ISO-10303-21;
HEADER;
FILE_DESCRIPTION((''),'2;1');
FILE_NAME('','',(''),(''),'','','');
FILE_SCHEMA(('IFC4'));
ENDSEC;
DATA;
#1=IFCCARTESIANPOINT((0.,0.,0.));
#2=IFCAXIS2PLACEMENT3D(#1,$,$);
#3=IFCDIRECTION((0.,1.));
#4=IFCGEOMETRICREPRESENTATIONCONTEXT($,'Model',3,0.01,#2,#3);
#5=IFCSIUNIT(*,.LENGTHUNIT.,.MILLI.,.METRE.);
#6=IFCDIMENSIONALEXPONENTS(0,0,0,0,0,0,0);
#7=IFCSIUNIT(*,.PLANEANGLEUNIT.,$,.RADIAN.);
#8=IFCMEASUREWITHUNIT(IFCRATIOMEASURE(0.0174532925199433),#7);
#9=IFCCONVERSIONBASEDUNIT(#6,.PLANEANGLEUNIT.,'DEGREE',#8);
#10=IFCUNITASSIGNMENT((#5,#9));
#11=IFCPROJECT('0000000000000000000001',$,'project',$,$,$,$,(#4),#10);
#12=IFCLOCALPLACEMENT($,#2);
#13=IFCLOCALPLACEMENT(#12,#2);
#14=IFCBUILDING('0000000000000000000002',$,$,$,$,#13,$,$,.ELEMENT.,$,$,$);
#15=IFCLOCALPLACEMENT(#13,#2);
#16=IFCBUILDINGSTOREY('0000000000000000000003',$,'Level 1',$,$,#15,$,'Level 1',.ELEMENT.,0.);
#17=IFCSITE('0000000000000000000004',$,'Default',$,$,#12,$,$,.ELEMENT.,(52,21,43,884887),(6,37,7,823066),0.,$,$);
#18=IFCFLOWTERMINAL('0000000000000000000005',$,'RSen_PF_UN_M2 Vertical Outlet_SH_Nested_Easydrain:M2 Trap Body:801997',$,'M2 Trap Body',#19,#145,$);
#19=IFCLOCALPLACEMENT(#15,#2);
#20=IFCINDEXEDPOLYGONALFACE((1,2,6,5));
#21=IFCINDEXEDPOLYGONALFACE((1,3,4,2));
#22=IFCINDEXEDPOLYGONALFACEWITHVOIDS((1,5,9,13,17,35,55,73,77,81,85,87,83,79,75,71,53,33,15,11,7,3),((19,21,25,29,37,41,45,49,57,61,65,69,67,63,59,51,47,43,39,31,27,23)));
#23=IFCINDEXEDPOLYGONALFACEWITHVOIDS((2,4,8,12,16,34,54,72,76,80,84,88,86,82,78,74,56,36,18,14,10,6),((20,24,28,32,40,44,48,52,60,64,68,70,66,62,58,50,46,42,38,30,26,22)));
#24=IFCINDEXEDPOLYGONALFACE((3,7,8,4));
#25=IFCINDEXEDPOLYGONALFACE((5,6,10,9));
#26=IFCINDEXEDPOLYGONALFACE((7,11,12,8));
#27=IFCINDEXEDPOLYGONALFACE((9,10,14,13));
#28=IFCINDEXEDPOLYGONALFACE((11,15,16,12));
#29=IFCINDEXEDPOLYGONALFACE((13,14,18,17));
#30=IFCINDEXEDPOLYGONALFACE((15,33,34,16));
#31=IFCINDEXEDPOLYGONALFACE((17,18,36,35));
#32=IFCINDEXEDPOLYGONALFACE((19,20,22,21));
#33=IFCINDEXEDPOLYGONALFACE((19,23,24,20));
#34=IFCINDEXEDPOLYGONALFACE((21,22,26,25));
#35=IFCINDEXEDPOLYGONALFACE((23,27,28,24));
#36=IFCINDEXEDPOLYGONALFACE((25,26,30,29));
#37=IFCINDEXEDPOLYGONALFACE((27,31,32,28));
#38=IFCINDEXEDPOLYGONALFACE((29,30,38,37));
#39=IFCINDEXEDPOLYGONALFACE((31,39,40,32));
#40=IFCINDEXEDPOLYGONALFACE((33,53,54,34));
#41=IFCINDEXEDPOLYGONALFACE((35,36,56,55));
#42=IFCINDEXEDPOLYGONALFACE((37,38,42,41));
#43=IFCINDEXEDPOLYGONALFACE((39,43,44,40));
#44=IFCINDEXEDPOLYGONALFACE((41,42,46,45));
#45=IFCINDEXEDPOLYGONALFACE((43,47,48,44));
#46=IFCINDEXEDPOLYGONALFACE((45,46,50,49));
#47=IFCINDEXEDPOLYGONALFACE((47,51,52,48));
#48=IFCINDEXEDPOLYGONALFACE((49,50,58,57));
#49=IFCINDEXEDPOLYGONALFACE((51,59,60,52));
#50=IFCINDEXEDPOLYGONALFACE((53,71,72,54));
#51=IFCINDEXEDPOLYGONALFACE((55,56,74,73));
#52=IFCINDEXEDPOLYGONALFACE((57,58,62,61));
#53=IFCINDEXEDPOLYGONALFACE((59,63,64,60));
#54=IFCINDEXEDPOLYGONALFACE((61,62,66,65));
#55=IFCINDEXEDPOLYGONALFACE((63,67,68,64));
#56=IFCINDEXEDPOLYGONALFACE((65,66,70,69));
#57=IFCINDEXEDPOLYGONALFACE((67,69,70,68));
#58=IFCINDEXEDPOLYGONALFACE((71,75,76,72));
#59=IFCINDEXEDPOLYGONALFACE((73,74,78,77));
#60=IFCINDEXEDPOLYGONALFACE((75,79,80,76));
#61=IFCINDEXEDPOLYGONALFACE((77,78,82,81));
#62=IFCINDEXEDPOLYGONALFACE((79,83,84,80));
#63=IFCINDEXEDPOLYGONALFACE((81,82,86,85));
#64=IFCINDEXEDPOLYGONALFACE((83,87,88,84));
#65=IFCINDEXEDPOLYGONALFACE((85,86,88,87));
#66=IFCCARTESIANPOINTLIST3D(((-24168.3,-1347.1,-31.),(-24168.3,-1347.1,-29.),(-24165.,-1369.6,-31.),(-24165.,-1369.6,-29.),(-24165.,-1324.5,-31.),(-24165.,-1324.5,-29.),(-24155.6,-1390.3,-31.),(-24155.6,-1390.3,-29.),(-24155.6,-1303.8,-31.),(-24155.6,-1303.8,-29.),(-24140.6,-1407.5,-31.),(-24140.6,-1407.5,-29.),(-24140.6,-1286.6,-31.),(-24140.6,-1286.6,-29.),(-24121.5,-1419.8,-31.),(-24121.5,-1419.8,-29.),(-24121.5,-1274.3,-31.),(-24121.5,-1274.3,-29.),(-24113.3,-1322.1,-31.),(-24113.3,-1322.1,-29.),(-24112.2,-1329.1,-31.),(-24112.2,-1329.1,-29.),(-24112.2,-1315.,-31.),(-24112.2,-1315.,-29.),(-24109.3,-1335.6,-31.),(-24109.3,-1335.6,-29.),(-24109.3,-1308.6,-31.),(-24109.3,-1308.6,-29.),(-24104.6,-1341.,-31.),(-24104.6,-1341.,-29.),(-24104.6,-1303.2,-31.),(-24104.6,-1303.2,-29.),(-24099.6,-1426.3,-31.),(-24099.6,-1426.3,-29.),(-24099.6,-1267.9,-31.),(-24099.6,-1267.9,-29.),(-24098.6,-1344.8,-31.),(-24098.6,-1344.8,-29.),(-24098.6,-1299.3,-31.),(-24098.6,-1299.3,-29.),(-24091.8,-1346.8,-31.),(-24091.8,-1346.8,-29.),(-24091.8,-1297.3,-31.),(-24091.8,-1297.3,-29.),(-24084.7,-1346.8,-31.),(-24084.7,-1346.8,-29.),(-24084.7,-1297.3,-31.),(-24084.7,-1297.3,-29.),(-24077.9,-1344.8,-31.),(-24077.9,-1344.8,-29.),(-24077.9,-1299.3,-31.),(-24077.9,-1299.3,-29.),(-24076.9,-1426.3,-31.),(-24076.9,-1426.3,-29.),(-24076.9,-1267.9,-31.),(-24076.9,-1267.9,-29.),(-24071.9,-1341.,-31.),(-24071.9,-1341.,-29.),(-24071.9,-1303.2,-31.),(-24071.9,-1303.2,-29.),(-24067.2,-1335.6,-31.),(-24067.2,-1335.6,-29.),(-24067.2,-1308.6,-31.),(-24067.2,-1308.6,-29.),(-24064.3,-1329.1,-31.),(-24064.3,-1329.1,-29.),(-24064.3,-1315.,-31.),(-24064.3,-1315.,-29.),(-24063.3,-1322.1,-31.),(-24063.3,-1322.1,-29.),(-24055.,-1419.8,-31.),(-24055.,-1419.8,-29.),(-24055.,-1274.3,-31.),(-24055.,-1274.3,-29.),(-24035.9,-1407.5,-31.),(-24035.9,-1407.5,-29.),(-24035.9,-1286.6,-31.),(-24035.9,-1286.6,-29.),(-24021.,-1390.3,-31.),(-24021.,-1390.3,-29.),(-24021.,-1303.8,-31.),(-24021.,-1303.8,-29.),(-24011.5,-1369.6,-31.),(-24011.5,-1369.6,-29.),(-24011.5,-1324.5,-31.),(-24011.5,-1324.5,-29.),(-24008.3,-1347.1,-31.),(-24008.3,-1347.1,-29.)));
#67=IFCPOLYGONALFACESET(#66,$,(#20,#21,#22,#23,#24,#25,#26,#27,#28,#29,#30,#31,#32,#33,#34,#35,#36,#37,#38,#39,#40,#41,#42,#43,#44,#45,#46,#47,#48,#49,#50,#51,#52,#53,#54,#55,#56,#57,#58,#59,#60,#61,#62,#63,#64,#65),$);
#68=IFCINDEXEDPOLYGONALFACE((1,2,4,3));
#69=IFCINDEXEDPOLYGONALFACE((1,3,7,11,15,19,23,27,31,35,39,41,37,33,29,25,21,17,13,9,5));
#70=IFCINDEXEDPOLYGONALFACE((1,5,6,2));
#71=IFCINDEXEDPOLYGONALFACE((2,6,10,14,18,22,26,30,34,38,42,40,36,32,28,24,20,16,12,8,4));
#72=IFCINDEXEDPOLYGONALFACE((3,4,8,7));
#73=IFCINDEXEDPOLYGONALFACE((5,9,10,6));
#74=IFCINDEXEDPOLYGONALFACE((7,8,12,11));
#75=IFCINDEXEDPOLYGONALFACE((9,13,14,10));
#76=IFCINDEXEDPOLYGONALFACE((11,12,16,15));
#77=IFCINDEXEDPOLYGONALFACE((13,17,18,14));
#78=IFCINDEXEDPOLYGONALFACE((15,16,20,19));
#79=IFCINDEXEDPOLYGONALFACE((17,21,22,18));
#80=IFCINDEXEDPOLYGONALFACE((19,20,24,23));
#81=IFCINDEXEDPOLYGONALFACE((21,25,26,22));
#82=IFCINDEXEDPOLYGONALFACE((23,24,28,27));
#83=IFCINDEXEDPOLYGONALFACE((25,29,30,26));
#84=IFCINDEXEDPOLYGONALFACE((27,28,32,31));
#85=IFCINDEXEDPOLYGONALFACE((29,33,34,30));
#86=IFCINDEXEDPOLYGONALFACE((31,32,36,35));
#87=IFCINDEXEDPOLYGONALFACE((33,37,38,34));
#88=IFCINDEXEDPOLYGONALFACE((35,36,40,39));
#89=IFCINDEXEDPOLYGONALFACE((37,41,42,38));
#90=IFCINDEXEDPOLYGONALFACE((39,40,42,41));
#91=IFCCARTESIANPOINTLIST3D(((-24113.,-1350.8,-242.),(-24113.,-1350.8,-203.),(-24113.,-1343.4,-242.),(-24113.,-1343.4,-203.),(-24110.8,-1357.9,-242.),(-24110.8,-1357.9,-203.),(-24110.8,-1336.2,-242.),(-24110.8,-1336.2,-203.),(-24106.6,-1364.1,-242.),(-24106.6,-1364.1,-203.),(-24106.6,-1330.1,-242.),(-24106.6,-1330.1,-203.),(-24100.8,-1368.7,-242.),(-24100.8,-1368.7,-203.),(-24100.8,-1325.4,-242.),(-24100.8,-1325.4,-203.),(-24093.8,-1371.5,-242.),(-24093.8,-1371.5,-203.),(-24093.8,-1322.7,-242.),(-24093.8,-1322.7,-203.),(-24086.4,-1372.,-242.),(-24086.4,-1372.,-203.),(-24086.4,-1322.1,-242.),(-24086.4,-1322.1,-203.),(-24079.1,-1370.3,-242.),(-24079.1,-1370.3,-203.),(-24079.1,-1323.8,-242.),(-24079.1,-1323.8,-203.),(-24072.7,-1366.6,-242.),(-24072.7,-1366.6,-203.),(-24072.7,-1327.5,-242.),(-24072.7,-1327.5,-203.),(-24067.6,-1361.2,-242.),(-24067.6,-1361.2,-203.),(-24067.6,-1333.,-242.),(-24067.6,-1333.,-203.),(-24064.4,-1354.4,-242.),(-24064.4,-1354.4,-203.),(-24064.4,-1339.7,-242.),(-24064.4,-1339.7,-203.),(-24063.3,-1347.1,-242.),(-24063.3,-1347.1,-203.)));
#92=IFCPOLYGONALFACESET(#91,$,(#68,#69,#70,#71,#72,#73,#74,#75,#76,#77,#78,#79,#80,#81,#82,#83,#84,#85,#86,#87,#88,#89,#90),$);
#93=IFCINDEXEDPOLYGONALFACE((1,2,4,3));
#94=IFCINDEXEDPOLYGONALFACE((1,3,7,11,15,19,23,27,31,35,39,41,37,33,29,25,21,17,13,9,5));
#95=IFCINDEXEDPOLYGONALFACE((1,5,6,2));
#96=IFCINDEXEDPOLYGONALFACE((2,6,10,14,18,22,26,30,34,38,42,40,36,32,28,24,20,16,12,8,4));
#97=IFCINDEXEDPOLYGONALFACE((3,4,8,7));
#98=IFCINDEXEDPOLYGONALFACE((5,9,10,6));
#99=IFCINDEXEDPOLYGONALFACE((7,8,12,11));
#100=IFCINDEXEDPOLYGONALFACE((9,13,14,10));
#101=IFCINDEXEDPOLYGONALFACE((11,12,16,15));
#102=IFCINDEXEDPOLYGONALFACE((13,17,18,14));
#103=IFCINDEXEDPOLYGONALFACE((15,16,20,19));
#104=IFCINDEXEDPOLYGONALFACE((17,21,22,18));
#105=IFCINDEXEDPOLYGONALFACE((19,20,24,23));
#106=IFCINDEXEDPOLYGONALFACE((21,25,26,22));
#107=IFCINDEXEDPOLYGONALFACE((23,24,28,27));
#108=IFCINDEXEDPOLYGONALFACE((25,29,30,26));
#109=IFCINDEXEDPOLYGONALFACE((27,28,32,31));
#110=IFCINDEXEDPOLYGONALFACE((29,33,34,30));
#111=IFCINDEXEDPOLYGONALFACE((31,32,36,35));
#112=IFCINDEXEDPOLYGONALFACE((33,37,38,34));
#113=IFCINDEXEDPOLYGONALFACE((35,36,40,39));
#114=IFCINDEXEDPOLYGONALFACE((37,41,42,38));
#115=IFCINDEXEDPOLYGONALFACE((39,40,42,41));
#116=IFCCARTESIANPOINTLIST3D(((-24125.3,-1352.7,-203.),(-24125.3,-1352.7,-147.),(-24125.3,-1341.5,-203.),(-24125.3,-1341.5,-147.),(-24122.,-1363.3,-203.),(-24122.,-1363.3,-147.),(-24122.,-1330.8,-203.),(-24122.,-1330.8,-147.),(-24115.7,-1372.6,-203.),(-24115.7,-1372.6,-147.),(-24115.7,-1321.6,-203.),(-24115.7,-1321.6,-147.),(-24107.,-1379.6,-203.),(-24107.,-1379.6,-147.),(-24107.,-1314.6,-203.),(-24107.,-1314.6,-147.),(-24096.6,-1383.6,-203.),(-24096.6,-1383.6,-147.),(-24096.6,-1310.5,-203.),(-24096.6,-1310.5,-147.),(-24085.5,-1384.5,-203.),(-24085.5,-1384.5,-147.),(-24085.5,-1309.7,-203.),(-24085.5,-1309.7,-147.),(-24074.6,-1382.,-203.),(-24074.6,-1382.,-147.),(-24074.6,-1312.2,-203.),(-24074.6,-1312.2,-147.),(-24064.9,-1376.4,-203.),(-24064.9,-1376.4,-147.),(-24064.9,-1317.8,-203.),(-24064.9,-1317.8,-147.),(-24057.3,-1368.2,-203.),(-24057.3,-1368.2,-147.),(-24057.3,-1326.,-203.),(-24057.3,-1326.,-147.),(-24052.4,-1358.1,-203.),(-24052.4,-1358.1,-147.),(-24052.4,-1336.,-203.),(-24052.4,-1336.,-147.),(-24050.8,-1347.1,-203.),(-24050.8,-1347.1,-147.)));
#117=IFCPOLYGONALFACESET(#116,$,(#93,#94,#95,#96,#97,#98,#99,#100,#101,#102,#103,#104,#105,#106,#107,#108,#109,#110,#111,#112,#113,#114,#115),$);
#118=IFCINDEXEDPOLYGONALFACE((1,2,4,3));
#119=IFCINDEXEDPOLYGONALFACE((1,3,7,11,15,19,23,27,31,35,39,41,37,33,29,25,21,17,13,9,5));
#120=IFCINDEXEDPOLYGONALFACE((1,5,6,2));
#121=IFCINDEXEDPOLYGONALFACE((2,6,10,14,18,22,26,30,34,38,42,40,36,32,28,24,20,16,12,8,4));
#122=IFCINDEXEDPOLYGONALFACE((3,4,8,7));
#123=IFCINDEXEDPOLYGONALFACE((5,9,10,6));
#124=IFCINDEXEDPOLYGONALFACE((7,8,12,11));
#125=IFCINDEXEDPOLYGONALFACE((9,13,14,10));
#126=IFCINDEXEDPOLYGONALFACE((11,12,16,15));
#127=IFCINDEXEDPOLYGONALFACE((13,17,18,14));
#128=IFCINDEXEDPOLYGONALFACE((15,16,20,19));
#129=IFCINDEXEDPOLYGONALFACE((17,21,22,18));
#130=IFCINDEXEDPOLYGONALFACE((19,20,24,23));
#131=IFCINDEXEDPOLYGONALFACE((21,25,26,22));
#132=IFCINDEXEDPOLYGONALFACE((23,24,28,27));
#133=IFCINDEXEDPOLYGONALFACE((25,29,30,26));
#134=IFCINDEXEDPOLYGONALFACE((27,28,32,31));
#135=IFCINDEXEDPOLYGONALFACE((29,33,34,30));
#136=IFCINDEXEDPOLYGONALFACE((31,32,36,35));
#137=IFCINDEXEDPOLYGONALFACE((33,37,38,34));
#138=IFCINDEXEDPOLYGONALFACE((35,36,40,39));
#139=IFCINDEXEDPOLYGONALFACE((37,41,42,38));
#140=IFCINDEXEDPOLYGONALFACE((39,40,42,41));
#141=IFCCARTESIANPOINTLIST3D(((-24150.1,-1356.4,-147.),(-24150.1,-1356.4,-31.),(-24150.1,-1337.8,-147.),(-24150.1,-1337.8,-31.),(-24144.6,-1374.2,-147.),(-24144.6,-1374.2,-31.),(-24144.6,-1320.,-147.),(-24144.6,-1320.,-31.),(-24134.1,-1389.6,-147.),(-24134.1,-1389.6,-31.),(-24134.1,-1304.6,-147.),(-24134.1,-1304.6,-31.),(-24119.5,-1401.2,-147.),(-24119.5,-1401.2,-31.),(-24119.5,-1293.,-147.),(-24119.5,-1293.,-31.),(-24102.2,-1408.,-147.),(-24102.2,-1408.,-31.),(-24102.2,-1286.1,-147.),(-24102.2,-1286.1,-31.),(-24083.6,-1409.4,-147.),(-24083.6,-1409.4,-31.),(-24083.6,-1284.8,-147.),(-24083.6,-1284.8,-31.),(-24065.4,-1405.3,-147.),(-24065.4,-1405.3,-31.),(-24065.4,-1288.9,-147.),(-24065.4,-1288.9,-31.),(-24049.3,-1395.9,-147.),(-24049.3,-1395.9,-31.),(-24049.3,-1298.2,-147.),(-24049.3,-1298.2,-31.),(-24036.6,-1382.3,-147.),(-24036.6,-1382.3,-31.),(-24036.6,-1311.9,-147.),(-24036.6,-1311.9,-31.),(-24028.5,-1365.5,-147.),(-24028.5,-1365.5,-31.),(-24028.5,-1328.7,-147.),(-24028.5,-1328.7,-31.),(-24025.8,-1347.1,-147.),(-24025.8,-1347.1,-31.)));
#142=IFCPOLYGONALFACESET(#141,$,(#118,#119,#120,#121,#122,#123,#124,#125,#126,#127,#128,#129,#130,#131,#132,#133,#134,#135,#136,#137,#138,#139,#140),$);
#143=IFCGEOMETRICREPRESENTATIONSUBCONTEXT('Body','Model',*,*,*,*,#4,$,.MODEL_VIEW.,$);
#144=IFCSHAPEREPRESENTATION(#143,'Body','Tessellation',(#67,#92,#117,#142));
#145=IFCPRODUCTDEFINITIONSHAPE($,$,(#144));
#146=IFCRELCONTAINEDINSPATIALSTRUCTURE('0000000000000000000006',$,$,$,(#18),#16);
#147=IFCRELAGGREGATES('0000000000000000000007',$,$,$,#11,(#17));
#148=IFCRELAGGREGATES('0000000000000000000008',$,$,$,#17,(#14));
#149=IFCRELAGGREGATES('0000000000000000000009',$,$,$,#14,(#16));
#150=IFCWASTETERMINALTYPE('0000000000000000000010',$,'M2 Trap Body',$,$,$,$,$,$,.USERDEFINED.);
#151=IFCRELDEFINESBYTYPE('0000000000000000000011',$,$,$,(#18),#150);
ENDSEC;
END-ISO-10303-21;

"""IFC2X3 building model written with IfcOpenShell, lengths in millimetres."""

from ifc_helpers import new_model, entity, si_unit, converted_unit, direction, frame, frame_2d, origin, origin_2d_with_axis, place, context, subcontext, project, spatial, circle_curve, parameter, trimmed, segment, composite_curve, circle, outline, extrude, source, transform, mapped, type_object, type_shapes, element, save


model = new_model("IFC2X3")

# Units and contexts
model_context = context("Model", 3, precision=0.01, world=origin(), true_north=direction((0.0, 1.0)))
body_context = subcontext(model_context, "Body", "Model", "MODEL_VIEW")
ifc_project = project(units=[si_unit("LENGTHUNIT", "METRE", prefix="MILLI"), converted_unit("PLANEANGLEUNIT", "DEGREE", entity("IfcRatioMeasure", 0.0174532925199433), si_unit("PLANEANGLEUNIT", "RADIAN"), dimensions=[0, 0, 0, 0, 0, 0, 0])], contexts=[model_context])

# Site, building, storey
site_placement = place(None, origin())
site = spatial("IfcSite", under=ifc_project, at=site_placement, Name="Default", CompositionType="ELEMENT", RefLatitude=(52, 21, 43, 884887), RefLongitude=(6, 37, 7, 823066), RefElevation=0.0)
building_placement = place(site_placement, origin())
building = spatial("IfcBuilding", under=site, at=building_placement, CompositionType="ELEMENT")
storey_placement = place(building_placement, origin())
storey = spatial("IfcBuildingStorey", under=building, at=storey_placement, Name="Level 1", LongName="Level 1", CompositionType="ELEMENT", Elevation=0.0)

# Flow terminal
waste_terminal_type_1 = type_object("IfcWasteTerminalType", Name="M2 Trap Body", PredefinedType="USERDEFINED")
shared_shape_1 = source(origin(), body_context, "Body", "SweptSolid", [
    extrude(outline(composite_curve([segment(trimmed(circle_curve(origin_2d_with_axis(), 80.0), [parameter(0.0)], [parameter(180.0)], True, "PARAMETER"), True, "CONTINUOUS"), segment(trimmed(circle_curve(origin_2d_with_axis(), 80.0), [parameter(180.0)], [parameter(360.0)], True, "PARAMETER"), True, "CONTINUOUS")], self_intersect=False), holes=[composite_curve([segment(trimmed(circle_curve(frame_2d((0.0, 25.0), x_axis=(1.0, 0.0)), 25.0), [parameter(180.0)], [parameter(360.0)], True, "PARAMETER"), False, "CONTINUOUS"), segment(trimmed(circle_curve(frame_2d((0.0, 25.0), x_axis=(1.0, 0.0)), 25.0), [parameter(0.0)], [parameter(180.0)], True, "PARAMETER"), False, "CONTINUOUS")], self_intersect=False)]), frame((0.0, -25.0, -2.0)), (0.0, 0.0, 1.0), 2.0),
    extrude(circle(Radius=25.0, at=frame_2d((0.0, 0.0), x_axis=(1.0, 0.0))), frame((0.0, -25.0, -213.0)), (0.0, 0.0, 1.0), 39.0),
    extrude(circle(Radius=37.5, at=frame_2d((0.0, 0.0), x_axis=(1.0, 0.0))), frame((0.0, -25.0, -174.0)), (0.0, 0.0, 1.0), 56.0),
    extrude(circle(Radius=62.5, at=frame_2d((0.0, 0.0), x_axis=(1.0, 0.0))), frame((0.0, -25.0, -118.0)), (0.0, 0.0, 1.0), 116.0),
])
type_shapes(waste_terminal_type_1, [shared_shape_1])
for number, where, name in (
    (1, (-24088.3, -1322.1, -29.0), "RSen_PF_UN_M2 Vertical Outlet_SH_Nested_Easydrain:M2 Trap Body:801997"),
):
    element("IfcFlowTerminal", number, at=place(storey_placement, frame(where)), inside=storey, type_object=waste_terminal_type_1, Name=name, ObjectType="M2 Trap Body", context=body_context, shape_type="MappedRepresentation", body=[
        mapped(shared_shape_1, transform((0.0, 0.0, 0.0), scale=1.0)),
    ])

save(model, "model.ifc")
